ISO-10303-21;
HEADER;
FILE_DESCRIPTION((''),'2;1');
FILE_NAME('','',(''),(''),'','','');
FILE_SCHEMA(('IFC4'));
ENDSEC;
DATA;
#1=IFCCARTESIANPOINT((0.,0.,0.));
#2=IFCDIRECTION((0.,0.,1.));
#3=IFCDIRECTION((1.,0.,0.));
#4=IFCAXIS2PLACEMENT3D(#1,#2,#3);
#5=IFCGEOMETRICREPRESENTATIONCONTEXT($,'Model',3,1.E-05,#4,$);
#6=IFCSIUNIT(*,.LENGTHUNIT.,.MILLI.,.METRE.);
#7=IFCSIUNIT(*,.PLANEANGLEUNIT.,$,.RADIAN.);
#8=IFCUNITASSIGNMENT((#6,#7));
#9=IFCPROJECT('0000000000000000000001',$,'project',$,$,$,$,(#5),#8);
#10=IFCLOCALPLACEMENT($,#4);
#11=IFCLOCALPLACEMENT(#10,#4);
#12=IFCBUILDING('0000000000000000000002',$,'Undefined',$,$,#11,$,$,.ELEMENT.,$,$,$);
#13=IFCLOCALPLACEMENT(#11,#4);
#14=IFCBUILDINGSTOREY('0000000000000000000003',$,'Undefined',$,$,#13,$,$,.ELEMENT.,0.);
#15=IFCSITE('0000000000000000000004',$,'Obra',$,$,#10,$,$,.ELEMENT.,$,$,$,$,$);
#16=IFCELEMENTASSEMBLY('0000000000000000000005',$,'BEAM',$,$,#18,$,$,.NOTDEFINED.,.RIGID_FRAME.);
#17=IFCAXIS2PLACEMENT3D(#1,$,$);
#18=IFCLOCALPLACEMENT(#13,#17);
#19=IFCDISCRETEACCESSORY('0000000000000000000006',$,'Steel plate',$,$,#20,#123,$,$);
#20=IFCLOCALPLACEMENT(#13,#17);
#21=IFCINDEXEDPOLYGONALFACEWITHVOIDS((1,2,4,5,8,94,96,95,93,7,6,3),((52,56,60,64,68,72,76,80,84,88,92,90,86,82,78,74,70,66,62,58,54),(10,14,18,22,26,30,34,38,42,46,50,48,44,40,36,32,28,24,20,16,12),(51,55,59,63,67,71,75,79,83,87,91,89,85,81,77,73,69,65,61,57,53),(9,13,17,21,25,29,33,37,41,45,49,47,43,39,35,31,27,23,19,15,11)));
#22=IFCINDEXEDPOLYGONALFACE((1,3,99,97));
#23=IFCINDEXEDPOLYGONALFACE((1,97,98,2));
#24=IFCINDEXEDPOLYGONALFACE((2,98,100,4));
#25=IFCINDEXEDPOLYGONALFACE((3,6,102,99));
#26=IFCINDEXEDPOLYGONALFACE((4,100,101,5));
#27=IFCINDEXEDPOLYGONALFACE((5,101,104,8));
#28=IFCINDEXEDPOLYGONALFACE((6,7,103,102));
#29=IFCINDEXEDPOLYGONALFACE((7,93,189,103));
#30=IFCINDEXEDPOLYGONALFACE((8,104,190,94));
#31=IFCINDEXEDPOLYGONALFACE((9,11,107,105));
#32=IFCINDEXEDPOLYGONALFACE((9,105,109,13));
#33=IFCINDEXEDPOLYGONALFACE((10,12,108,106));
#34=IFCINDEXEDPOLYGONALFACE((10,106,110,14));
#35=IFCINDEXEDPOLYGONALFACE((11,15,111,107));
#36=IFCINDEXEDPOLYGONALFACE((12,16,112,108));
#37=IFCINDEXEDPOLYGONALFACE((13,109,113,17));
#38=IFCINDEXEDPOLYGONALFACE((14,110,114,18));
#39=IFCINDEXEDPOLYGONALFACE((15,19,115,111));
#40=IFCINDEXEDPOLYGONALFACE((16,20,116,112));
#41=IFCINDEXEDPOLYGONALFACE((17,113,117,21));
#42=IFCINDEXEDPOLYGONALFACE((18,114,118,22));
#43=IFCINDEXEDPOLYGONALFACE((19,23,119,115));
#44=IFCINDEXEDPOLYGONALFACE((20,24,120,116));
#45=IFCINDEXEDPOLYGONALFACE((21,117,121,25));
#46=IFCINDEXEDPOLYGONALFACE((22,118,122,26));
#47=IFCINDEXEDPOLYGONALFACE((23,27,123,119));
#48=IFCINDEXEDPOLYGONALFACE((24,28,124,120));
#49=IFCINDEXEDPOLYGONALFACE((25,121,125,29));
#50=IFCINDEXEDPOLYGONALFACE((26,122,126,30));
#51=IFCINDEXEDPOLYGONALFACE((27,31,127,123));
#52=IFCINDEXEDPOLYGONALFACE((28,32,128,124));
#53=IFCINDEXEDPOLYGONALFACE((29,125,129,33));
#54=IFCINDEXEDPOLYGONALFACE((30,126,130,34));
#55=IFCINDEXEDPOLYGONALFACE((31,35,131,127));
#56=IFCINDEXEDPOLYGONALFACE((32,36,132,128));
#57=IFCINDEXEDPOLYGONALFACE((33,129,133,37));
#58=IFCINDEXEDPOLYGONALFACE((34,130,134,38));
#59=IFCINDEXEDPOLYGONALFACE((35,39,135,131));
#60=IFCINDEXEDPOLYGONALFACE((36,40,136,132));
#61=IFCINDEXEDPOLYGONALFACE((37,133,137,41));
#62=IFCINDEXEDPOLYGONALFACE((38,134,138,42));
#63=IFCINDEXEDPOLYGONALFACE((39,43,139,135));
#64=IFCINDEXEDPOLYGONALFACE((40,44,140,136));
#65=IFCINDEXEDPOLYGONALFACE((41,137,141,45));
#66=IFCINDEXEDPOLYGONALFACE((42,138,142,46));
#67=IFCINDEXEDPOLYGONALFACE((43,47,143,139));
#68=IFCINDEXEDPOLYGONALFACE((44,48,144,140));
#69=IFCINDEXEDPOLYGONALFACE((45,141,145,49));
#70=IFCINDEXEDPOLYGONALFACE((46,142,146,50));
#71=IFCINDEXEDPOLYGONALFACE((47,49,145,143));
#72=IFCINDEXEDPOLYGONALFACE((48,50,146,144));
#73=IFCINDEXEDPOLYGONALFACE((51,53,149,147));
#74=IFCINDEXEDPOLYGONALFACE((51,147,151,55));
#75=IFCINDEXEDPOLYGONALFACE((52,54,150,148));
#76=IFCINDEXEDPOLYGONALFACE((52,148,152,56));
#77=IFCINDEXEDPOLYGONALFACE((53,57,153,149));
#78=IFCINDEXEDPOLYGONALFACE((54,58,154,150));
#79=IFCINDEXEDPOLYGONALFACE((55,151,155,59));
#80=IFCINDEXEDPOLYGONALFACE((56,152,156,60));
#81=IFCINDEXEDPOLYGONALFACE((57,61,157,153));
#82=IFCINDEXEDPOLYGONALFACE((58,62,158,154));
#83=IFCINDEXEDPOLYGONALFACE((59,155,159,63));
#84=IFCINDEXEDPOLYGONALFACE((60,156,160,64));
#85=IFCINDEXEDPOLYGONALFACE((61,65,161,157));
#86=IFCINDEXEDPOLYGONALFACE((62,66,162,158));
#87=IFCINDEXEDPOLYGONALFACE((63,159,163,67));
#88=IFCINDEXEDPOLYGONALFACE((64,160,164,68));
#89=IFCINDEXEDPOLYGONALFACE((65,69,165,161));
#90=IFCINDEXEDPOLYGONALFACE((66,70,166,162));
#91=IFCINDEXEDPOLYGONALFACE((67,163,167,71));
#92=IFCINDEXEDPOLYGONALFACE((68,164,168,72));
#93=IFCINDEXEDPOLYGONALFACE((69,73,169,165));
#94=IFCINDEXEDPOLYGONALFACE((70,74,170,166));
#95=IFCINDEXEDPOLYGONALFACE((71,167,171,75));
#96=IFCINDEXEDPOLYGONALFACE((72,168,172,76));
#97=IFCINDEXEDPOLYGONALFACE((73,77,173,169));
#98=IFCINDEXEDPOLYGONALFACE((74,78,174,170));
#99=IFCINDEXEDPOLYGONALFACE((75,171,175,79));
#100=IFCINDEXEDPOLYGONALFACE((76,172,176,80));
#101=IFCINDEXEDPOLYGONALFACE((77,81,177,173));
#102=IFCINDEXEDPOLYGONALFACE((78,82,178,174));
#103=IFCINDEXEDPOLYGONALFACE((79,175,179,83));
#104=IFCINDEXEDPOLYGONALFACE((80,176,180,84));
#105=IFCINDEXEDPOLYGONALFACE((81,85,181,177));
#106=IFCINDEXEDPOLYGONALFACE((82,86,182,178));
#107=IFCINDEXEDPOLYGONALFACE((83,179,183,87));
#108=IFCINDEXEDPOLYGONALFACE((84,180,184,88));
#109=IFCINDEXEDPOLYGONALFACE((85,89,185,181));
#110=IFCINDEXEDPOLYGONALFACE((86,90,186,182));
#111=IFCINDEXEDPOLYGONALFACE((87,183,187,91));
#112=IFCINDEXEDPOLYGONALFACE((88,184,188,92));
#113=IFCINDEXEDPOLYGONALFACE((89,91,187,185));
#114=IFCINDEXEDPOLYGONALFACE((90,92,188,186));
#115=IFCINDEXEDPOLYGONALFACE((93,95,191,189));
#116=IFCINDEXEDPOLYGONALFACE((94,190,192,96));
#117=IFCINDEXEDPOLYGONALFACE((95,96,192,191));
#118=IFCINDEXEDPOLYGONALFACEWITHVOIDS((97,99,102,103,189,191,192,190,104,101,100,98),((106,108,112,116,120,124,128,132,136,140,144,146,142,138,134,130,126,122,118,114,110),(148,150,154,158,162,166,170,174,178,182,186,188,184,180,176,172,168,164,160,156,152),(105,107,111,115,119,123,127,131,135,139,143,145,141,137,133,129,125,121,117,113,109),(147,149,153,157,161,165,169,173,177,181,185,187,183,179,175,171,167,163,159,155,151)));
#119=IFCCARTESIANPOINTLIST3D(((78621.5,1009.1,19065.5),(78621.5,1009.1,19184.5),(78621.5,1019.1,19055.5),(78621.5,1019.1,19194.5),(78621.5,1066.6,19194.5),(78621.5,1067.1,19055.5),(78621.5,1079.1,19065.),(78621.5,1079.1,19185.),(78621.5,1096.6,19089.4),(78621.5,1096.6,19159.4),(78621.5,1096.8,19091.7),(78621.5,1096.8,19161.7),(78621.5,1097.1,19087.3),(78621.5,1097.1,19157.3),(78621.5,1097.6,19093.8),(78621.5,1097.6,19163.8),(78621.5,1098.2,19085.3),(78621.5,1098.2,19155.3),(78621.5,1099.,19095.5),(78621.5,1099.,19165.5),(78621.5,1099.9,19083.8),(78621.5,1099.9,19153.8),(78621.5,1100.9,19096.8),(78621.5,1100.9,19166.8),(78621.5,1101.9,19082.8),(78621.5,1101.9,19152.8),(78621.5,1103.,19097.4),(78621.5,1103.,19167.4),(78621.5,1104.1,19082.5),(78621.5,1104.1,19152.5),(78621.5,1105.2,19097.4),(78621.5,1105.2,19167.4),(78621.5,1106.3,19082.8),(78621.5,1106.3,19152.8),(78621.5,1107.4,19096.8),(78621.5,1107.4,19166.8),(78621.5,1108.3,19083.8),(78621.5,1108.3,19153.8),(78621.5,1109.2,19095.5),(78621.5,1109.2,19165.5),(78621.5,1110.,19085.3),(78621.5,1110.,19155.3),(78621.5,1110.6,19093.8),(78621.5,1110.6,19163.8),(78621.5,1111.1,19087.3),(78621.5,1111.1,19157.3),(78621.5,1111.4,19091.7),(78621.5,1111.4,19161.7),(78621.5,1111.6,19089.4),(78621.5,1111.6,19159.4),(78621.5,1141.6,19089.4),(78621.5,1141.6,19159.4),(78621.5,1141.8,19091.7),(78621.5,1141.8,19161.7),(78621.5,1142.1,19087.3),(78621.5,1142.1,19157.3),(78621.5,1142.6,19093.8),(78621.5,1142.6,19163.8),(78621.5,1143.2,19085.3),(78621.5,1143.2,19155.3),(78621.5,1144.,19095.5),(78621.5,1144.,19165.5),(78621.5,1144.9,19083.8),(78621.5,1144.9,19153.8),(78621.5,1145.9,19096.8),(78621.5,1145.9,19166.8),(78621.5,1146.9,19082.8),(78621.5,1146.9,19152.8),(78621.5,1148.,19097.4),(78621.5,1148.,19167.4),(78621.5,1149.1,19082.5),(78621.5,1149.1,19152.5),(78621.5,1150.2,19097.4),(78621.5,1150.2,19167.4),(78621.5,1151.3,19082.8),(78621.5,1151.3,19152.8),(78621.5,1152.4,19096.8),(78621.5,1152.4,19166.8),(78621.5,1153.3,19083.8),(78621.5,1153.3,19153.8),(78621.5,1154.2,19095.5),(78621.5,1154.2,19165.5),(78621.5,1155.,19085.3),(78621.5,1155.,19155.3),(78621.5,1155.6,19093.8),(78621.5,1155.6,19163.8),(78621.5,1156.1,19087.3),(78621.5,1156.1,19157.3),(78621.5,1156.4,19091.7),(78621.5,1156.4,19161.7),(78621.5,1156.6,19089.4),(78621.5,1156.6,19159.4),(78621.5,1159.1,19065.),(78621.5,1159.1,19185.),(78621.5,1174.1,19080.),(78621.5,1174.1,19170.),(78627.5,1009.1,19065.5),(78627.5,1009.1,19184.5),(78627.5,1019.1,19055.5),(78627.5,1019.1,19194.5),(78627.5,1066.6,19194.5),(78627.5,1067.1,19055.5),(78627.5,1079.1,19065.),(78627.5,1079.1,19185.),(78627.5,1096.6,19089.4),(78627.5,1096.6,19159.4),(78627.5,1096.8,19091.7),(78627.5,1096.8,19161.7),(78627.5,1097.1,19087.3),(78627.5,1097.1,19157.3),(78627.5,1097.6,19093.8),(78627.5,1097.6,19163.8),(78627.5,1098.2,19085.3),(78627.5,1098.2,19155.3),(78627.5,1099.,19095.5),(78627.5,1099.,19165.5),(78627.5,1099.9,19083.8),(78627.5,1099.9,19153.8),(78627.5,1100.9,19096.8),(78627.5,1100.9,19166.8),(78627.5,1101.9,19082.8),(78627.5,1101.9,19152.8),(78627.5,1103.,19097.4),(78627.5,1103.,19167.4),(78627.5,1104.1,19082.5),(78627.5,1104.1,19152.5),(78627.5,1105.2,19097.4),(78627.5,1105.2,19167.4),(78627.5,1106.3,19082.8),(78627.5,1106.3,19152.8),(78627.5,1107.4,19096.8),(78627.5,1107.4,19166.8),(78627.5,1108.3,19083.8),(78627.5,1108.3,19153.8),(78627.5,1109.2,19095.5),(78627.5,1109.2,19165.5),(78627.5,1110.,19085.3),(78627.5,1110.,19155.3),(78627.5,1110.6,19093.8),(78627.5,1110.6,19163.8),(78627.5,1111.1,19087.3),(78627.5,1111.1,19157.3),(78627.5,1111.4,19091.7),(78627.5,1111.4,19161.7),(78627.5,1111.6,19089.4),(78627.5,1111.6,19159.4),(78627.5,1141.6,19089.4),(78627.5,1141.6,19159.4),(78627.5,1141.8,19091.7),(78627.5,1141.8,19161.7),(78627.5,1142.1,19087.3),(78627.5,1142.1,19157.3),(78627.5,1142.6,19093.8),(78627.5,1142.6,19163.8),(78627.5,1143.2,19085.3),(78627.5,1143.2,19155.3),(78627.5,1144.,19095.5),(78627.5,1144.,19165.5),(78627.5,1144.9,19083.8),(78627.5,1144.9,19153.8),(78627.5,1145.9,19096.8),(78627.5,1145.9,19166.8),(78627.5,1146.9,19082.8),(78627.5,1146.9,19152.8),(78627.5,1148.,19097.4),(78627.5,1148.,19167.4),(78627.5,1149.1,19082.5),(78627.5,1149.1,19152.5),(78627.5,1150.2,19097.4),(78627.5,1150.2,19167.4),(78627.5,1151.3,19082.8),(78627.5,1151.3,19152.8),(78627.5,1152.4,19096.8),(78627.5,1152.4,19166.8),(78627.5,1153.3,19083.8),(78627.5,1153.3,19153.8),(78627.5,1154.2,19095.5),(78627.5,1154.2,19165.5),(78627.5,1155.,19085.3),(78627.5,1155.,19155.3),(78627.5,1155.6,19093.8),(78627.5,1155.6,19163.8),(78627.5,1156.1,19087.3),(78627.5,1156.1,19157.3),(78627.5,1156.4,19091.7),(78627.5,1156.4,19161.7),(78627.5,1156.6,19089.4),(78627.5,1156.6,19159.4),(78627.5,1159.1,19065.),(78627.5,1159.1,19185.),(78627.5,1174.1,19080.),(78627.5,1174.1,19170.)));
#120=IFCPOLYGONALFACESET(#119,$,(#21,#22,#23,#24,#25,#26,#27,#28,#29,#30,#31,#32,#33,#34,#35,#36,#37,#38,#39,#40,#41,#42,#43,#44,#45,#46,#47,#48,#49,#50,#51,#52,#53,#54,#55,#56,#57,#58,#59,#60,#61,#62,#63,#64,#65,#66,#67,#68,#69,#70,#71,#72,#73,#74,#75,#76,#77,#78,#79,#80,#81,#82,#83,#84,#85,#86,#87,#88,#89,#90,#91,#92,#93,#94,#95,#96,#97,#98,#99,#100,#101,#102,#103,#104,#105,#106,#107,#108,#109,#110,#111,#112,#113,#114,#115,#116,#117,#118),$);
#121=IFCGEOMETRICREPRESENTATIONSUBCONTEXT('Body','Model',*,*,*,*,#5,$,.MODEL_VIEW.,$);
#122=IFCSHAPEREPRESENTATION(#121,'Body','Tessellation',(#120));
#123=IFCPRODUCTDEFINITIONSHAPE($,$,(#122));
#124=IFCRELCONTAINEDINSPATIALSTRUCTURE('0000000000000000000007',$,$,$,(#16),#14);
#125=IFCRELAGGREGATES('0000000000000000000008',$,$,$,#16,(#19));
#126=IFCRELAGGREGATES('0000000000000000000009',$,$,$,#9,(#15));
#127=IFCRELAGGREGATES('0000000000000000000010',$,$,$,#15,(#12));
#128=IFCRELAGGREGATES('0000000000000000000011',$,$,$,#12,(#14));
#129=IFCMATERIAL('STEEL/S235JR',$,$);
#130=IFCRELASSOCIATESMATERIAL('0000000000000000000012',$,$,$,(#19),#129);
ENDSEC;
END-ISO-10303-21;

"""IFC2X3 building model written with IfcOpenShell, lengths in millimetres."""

from ifc_helpers import new_model, si_unit, frame, origin_with_axes, origin_2d_with_axis, place, context, subcontext, project, spatial, polyline, circle, outline, extrude, source, transform, mapped, material, element, aggregate, save


model = new_model("IFC2X3")

# Units and contexts
model_context = context("Model", 3, precision=1e-05, world=origin_with_axes())
body_context = subcontext(model_context, "Body", "Model", "MODEL_VIEW")
ifc_project = project(units=[si_unit("LENGTHUNIT", "METRE", prefix="MILLI"), si_unit("PLANEANGLEUNIT", "RADIAN")], contexts=[model_context])

# Site, building, storey
site_placement = place(None, origin_with_axes())
site = spatial("IfcSite", under=ifc_project, at=site_placement, Name="Obra", CompositionType="ELEMENT")
building_placement = place(site_placement, origin_with_axes())
building = spatial("IfcBuilding", under=site, at=building_placement, Name="Undefined", CompositionType="ELEMENT")
storey_placement = place(building_placement, origin_with_axes())
storey = spatial("IfcBuildingStorey", under=building, at=storey_placement, Name="Undefined", CompositionType="ELEMENT", Elevation=0.0)

# Shared definitions
ifc_material_1 = material(Name="STEEL/S235JR")

# Element assembly
assembly_1_placement = place(storey_placement, origin_with_axes())
assembly_1 = element("IfcElementAssembly", 1, at=assembly_1_placement, inside=storey, Name="BEAM", AssemblyPlace="NOTDEFINED", PredefinedType="RIGID_FRAME")

# Shared definitions
shared_shape_1 = source(origin_with_axes(), body_context, "Body", "SweptSolid", [
    extrude(circle(Radius=7.5, at=origin_2d_with_axis()), frame((0.0, 2.4, 0.0), z_axis=(0.0, 1.0, 0.0), x_axis=(1.0, 0.0, 0.0)), (0.0, 0.0, 1.0), 6.2),
])

# Discrete accessory, opening
discrete_accessory_1_placement = place(assembly_1_placement, frame((78624.5, 1009.1, 19065.5), z_axis=(1.0, 0.0, 0.0), x_axis=(0.0, 0.707107, -0.707107)))
discrete_accessory_1 = element("IfcDiscreteAccessory", 2, at=discrete_accessory_1_placement, material=ifc_material_1, Name="Steel plate", context=body_context, shape_type="SweptSolid", body=[
    extrude(outline(polyline([(0.0, 0.0), (14.1, 0.0), (48.1, 33.9), (49.9, 49.1), (106.4, 105.7), (106.4, 126.9), (42.8, 190.6), (21.6, 190.6), (-35.0, 134.0), (-50.6, 131.9), (-84.1, 98.3), (-84.1, 84.1), (0.0, 0.0)])), frame((0.0, 0.0, -3.0), z_axis=(0.0, 0.0, 1.0), x_axis=(1.0, 0.0, 0.0)), (0.0, 0.0, 1.0), 6.0),
])
opening_1_placement = place(assembly_1_placement, frame((78630.0, 1126.6, 19160.0), z_axis=(0.0, 1.0, 0.0), x_axis=(0.0, 0.0, -1.0)))
element("IfcOpeningElement", 3, at=opening_1_placement, cuts=discrete_accessory_1, ObjectType="Opening", context=body_context, shape_type="MappedRepresentation", body=[
    mapped(shared_shape_1, transform((0.0, 0.0, -22.5))),
    mapped(shared_shape_1, transform((70.0, 0.0, -22.5))),
    mapped(shared_shape_1, transform((0.0, 0.0, 22.5))),
    mapped(shared_shape_1, transform((70.0, 0.0, 22.5))),
])
aggregate(assembly_1, [discrete_accessory_1])

save(model, "model.ifc")
